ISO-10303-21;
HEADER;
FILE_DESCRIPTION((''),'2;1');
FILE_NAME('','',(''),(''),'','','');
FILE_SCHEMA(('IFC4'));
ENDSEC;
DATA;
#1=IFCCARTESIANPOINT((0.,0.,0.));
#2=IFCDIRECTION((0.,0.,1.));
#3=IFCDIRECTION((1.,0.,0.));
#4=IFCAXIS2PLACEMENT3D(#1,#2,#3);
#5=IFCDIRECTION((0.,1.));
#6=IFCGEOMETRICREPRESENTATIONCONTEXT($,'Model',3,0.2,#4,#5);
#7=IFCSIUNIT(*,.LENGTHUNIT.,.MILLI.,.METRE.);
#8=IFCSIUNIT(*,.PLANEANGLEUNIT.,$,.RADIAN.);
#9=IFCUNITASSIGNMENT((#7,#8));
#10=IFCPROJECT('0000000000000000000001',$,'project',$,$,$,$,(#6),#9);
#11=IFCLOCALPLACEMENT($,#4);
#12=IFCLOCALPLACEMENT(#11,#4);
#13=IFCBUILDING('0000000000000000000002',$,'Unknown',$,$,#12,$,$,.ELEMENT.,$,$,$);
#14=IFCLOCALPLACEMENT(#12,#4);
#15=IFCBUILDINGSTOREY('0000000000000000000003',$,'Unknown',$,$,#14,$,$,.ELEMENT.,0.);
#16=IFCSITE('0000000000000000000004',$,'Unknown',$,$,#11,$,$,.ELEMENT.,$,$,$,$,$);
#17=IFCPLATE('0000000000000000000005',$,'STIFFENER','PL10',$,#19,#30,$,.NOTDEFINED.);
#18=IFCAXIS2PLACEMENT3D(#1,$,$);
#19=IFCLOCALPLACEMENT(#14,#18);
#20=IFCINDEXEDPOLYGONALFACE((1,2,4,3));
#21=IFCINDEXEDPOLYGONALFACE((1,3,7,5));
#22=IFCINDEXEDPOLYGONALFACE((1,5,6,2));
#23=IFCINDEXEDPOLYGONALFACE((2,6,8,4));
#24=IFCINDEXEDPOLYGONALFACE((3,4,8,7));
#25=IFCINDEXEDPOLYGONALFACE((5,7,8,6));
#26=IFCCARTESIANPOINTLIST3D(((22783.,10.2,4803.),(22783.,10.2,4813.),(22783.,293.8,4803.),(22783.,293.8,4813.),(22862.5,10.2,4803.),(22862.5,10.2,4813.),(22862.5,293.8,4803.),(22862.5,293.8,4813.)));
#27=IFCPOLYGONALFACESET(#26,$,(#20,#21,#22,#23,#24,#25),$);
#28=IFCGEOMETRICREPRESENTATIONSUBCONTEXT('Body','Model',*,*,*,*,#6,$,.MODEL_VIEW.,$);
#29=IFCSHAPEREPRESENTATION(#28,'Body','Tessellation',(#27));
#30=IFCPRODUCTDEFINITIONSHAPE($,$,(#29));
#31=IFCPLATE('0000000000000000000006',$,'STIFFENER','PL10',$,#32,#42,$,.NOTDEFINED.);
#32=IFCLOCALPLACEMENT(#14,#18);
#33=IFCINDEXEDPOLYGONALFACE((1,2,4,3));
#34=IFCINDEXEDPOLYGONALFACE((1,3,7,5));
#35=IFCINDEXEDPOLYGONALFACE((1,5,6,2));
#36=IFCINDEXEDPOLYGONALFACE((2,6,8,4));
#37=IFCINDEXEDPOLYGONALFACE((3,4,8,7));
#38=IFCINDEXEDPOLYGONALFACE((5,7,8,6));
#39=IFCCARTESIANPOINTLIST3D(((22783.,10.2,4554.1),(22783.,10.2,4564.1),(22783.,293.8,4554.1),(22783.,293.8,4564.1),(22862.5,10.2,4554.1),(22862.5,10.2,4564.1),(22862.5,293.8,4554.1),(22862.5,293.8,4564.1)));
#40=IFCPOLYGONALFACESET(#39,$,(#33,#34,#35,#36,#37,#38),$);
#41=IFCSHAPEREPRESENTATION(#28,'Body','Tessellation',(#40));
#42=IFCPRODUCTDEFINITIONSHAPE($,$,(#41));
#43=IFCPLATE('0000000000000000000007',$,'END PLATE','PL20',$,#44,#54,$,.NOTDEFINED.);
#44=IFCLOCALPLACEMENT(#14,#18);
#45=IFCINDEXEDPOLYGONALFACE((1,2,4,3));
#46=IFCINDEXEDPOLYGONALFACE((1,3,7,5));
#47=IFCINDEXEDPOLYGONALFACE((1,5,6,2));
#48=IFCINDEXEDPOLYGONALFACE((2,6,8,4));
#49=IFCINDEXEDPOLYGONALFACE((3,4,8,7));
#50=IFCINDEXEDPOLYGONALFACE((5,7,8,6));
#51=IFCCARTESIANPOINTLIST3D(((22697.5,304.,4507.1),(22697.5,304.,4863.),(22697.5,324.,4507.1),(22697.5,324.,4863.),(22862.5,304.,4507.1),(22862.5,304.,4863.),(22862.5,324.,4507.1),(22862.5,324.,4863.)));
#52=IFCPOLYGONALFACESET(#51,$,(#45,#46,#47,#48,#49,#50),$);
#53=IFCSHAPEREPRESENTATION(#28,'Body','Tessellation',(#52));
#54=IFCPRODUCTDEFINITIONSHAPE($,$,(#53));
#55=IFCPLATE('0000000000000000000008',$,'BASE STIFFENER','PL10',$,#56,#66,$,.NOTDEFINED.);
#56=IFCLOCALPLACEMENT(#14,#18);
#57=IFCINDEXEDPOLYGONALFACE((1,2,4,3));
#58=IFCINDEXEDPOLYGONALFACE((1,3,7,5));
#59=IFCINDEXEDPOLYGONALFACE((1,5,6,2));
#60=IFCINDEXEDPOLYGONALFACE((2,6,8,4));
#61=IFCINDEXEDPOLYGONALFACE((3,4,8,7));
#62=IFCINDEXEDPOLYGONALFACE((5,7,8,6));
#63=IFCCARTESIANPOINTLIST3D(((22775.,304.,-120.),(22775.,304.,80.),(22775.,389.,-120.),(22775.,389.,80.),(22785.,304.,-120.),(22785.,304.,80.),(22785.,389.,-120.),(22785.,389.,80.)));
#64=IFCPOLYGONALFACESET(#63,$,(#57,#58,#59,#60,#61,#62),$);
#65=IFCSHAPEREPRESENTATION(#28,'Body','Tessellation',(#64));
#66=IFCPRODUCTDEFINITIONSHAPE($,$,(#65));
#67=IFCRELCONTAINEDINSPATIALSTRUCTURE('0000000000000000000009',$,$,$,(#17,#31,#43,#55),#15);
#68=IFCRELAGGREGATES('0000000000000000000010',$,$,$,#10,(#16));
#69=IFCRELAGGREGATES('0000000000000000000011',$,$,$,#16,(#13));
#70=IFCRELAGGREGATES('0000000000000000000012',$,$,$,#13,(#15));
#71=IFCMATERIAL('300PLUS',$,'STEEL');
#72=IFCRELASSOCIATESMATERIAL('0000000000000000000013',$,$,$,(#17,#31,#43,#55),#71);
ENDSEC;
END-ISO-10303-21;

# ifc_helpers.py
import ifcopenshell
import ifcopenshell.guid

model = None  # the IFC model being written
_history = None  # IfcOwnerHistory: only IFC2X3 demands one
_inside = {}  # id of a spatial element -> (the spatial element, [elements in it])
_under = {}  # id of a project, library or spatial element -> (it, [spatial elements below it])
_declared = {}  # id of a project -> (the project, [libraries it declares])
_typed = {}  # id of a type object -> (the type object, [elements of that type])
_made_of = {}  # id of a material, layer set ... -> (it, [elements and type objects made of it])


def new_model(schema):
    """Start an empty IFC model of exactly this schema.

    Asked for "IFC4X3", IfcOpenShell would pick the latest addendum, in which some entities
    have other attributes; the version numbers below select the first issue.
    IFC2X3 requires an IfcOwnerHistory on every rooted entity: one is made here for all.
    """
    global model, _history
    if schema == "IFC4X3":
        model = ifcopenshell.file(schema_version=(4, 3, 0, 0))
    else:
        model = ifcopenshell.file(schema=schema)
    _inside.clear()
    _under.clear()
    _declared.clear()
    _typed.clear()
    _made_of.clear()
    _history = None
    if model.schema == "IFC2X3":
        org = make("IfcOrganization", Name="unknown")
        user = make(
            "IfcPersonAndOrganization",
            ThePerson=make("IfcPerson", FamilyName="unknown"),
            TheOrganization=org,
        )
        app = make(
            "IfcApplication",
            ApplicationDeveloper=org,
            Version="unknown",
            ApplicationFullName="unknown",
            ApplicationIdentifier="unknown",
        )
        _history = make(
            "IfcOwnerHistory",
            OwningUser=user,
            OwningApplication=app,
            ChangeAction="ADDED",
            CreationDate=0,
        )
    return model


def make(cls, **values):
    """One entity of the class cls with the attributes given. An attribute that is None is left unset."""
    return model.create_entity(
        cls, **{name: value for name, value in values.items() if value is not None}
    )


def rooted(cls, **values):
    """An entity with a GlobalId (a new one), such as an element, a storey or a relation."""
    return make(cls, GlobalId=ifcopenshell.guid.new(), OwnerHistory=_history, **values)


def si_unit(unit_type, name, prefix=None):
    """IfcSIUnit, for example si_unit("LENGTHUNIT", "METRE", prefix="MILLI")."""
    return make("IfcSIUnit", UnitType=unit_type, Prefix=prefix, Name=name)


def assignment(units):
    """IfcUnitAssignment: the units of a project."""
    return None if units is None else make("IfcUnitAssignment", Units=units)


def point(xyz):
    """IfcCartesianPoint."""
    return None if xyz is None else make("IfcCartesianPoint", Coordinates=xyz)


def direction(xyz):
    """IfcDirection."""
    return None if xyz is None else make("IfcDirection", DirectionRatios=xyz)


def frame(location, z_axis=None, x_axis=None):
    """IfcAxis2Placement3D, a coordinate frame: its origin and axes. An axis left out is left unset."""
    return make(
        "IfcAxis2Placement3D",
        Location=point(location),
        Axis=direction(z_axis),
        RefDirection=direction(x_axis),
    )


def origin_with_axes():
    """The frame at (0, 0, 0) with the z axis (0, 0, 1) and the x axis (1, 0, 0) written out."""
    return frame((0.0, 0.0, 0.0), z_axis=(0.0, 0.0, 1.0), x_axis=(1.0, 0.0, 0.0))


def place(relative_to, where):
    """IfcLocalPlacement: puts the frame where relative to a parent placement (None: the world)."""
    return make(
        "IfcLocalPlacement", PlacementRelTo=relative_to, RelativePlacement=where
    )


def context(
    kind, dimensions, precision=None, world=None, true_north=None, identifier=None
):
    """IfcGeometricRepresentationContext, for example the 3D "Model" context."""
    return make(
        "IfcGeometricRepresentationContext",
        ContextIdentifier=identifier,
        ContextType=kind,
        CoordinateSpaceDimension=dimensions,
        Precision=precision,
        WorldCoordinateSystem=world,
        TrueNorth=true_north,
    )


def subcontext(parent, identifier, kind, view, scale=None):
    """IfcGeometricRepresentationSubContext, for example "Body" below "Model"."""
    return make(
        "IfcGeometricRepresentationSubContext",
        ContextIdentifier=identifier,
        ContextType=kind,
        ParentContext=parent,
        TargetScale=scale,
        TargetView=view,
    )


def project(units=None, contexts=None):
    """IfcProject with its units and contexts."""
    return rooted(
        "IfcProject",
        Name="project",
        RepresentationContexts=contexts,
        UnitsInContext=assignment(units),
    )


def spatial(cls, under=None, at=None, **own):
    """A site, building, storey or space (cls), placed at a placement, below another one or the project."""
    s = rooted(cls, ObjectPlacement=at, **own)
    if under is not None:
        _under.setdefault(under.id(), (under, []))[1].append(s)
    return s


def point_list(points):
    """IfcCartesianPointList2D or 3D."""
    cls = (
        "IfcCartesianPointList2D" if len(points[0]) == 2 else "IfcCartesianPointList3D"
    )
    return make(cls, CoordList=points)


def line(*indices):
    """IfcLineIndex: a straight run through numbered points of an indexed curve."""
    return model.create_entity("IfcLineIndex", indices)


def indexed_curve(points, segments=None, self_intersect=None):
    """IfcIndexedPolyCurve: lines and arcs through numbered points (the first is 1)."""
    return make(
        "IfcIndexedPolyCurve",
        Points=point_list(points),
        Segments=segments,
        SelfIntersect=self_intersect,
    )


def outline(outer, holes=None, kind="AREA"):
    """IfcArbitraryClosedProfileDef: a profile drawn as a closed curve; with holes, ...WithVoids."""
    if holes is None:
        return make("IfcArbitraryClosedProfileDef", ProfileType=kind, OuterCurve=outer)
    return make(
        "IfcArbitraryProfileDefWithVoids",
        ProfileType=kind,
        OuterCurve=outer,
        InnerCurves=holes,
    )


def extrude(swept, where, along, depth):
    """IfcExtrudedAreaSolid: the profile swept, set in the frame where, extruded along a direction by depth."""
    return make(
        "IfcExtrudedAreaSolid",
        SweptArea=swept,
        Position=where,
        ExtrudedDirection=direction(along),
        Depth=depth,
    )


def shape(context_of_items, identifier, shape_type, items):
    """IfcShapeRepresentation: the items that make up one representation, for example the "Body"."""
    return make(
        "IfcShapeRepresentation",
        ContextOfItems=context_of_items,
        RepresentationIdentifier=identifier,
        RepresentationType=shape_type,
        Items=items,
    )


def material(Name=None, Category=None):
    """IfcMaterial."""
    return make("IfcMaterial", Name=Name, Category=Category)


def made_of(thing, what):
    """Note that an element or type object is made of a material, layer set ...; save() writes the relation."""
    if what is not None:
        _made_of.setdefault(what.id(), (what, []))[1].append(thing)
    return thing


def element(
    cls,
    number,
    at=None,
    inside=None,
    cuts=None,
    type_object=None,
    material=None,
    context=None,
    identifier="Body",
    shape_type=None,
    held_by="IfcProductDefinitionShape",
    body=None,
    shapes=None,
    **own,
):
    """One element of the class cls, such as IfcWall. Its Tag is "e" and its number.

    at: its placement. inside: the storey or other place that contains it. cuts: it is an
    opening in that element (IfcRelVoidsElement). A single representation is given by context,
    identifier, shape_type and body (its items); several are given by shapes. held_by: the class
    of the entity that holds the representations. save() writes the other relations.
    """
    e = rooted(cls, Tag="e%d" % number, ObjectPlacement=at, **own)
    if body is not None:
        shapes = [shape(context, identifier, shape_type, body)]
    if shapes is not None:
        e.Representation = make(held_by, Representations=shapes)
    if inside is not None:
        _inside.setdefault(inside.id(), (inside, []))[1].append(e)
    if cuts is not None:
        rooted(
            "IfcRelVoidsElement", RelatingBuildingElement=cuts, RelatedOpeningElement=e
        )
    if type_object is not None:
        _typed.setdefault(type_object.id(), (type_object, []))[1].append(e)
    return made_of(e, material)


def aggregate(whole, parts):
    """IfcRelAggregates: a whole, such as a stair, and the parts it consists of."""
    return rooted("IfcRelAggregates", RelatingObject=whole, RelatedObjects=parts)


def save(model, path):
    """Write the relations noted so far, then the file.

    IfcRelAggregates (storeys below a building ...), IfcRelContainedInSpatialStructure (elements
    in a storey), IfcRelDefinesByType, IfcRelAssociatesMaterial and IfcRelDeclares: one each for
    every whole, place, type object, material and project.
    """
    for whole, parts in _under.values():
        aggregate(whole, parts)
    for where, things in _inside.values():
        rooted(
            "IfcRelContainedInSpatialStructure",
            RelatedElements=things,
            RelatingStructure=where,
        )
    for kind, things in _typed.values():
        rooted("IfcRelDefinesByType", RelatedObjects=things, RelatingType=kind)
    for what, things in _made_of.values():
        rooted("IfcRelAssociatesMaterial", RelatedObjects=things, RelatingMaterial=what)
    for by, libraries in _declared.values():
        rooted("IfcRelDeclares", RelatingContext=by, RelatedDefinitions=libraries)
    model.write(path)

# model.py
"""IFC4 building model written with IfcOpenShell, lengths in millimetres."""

from ifc_helpers import new_model, si_unit, direction, frame, origin_with_axes, place, context, subcontext, project, spatial, line, indexed_curve, outline, extrude, material, element, save


model = new_model("IFC4")

# Units and contexts
model_context = context("Model", 3, precision=0.2, world=origin_with_axes(), true_north=direction((0.0, 1.0)))
body_context = subcontext(model_context, "Body", "Model", "MODEL_VIEW")
ifc_project = project(units=[si_unit("LENGTHUNIT", "METRE", prefix="MILLI"), si_unit("PLANEANGLEUNIT", "RADIAN")], contexts=[model_context])

# Site, building, storey
site_placement = place(None, origin_with_axes())
site = spatial("IfcSite", under=ifc_project, at=site_placement, Name="Unknown", CompositionType="ELEMENT")
building_placement = place(site_placement, origin_with_axes())
building = spatial("IfcBuilding", under=site, at=building_placement, Name="Unknown", CompositionType="ELEMENT")
storey_placement = place(building_placement, origin_with_axes())
storey = spatial("IfcBuildingStorey", under=building, at=storey_placement, Name="Unknown", CompositionType="ELEMENT", Elevation=0.0)

# Shared definitions
ifc_material_1 = material(Name="300PLUS", Category="STEEL")

# Plates
for number, where, z_axis, x_axis, name in (
    (1, (22783.0, 10.2, 4808.0), (0.0, 0.0, 1.0), (1.0, 0.0, 0.0), "STIFFENER"),
    (2, (22783.0, 10.2, 4559.1), (0.0, 0.0, 1.0), (1.0, 0.0, 0.0), "STIFFENER"),
):
    element("IfcPlate", number, at=place(storey_placement, frame(where, z_axis=z_axis, x_axis=x_axis)), inside=storey, material=ifc_material_1, Name=name, Description="PL10", PredefinedType="NOTDEFINED", context=body_context, shape_type="SolidModel", body=[
        extrude(outline(indexed_curve([(0.0, 0.0), (79.5, 0.0), (79.5, 283.6), (0.0, 283.6)], segments=[line(1, 2, 3, 4, 1)])), frame((0.0, 0.0, 5.0), z_axis=(0.0, 0.0, 1.0), x_axis=(1.0, 0.0, 0.0)), (0.0, 0.0, -1.0), 10.0),
    ])
plate_1_placement = place(storey_placement, frame((22697.5, 314.0, 4507.1), z_axis=(0.0, -1.0, 0.0), x_axis=(1.0, 0.0, 0.0)))
element("IfcPlate", 3, at=plate_1_placement, inside=storey, material=ifc_material_1, Name="END PLATE", Description="PL20", PredefinedType="NOTDEFINED", context=body_context, shape_type="SolidModel", body=[
    extrude(outline(indexed_curve([(0.0, 0.0), (165.0, 0.0), (165.0, 355.9), (0.0, 355.9)], segments=[line(1, 2, 3, 4, 1)])), frame((0.0, 0.0, 10.0), z_axis=(0.0, 0.0, 1.0), x_axis=(1.0, 0.0, 0.0)), (0.0, 0.0, -1.0), 20.0),
])
plate_2_placement = place(storey_placement, frame((22780.0, 304.0, -120.0), z_axis=(1.0, 0.0, 0.0), x_axis=(0.0, 1.0, 0.0)))
element("IfcPlate", 4, at=plate_2_placement, inside=storey, material=ifc_material_1, Name="BASE STIFFENER", Description="PL10", PredefinedType="NOTDEFINED", context=body_context, shape_type="SolidModel", body=[
    extrude(outline(indexed_curve([(0.0, 0.0), (85.0, 0.0), (85.0, 200.0), (0.0, 200.0)], segments=[line(1, 2, 3, 4, 1)])), frame((0.0, 0.0, 5.0), z_axis=(0.0, 0.0, 1.0), x_axis=(1.0, 0.0, 0.0)), (0.0, 0.0, -1.0), 10.0),
])

save(model, "model.ifc")
